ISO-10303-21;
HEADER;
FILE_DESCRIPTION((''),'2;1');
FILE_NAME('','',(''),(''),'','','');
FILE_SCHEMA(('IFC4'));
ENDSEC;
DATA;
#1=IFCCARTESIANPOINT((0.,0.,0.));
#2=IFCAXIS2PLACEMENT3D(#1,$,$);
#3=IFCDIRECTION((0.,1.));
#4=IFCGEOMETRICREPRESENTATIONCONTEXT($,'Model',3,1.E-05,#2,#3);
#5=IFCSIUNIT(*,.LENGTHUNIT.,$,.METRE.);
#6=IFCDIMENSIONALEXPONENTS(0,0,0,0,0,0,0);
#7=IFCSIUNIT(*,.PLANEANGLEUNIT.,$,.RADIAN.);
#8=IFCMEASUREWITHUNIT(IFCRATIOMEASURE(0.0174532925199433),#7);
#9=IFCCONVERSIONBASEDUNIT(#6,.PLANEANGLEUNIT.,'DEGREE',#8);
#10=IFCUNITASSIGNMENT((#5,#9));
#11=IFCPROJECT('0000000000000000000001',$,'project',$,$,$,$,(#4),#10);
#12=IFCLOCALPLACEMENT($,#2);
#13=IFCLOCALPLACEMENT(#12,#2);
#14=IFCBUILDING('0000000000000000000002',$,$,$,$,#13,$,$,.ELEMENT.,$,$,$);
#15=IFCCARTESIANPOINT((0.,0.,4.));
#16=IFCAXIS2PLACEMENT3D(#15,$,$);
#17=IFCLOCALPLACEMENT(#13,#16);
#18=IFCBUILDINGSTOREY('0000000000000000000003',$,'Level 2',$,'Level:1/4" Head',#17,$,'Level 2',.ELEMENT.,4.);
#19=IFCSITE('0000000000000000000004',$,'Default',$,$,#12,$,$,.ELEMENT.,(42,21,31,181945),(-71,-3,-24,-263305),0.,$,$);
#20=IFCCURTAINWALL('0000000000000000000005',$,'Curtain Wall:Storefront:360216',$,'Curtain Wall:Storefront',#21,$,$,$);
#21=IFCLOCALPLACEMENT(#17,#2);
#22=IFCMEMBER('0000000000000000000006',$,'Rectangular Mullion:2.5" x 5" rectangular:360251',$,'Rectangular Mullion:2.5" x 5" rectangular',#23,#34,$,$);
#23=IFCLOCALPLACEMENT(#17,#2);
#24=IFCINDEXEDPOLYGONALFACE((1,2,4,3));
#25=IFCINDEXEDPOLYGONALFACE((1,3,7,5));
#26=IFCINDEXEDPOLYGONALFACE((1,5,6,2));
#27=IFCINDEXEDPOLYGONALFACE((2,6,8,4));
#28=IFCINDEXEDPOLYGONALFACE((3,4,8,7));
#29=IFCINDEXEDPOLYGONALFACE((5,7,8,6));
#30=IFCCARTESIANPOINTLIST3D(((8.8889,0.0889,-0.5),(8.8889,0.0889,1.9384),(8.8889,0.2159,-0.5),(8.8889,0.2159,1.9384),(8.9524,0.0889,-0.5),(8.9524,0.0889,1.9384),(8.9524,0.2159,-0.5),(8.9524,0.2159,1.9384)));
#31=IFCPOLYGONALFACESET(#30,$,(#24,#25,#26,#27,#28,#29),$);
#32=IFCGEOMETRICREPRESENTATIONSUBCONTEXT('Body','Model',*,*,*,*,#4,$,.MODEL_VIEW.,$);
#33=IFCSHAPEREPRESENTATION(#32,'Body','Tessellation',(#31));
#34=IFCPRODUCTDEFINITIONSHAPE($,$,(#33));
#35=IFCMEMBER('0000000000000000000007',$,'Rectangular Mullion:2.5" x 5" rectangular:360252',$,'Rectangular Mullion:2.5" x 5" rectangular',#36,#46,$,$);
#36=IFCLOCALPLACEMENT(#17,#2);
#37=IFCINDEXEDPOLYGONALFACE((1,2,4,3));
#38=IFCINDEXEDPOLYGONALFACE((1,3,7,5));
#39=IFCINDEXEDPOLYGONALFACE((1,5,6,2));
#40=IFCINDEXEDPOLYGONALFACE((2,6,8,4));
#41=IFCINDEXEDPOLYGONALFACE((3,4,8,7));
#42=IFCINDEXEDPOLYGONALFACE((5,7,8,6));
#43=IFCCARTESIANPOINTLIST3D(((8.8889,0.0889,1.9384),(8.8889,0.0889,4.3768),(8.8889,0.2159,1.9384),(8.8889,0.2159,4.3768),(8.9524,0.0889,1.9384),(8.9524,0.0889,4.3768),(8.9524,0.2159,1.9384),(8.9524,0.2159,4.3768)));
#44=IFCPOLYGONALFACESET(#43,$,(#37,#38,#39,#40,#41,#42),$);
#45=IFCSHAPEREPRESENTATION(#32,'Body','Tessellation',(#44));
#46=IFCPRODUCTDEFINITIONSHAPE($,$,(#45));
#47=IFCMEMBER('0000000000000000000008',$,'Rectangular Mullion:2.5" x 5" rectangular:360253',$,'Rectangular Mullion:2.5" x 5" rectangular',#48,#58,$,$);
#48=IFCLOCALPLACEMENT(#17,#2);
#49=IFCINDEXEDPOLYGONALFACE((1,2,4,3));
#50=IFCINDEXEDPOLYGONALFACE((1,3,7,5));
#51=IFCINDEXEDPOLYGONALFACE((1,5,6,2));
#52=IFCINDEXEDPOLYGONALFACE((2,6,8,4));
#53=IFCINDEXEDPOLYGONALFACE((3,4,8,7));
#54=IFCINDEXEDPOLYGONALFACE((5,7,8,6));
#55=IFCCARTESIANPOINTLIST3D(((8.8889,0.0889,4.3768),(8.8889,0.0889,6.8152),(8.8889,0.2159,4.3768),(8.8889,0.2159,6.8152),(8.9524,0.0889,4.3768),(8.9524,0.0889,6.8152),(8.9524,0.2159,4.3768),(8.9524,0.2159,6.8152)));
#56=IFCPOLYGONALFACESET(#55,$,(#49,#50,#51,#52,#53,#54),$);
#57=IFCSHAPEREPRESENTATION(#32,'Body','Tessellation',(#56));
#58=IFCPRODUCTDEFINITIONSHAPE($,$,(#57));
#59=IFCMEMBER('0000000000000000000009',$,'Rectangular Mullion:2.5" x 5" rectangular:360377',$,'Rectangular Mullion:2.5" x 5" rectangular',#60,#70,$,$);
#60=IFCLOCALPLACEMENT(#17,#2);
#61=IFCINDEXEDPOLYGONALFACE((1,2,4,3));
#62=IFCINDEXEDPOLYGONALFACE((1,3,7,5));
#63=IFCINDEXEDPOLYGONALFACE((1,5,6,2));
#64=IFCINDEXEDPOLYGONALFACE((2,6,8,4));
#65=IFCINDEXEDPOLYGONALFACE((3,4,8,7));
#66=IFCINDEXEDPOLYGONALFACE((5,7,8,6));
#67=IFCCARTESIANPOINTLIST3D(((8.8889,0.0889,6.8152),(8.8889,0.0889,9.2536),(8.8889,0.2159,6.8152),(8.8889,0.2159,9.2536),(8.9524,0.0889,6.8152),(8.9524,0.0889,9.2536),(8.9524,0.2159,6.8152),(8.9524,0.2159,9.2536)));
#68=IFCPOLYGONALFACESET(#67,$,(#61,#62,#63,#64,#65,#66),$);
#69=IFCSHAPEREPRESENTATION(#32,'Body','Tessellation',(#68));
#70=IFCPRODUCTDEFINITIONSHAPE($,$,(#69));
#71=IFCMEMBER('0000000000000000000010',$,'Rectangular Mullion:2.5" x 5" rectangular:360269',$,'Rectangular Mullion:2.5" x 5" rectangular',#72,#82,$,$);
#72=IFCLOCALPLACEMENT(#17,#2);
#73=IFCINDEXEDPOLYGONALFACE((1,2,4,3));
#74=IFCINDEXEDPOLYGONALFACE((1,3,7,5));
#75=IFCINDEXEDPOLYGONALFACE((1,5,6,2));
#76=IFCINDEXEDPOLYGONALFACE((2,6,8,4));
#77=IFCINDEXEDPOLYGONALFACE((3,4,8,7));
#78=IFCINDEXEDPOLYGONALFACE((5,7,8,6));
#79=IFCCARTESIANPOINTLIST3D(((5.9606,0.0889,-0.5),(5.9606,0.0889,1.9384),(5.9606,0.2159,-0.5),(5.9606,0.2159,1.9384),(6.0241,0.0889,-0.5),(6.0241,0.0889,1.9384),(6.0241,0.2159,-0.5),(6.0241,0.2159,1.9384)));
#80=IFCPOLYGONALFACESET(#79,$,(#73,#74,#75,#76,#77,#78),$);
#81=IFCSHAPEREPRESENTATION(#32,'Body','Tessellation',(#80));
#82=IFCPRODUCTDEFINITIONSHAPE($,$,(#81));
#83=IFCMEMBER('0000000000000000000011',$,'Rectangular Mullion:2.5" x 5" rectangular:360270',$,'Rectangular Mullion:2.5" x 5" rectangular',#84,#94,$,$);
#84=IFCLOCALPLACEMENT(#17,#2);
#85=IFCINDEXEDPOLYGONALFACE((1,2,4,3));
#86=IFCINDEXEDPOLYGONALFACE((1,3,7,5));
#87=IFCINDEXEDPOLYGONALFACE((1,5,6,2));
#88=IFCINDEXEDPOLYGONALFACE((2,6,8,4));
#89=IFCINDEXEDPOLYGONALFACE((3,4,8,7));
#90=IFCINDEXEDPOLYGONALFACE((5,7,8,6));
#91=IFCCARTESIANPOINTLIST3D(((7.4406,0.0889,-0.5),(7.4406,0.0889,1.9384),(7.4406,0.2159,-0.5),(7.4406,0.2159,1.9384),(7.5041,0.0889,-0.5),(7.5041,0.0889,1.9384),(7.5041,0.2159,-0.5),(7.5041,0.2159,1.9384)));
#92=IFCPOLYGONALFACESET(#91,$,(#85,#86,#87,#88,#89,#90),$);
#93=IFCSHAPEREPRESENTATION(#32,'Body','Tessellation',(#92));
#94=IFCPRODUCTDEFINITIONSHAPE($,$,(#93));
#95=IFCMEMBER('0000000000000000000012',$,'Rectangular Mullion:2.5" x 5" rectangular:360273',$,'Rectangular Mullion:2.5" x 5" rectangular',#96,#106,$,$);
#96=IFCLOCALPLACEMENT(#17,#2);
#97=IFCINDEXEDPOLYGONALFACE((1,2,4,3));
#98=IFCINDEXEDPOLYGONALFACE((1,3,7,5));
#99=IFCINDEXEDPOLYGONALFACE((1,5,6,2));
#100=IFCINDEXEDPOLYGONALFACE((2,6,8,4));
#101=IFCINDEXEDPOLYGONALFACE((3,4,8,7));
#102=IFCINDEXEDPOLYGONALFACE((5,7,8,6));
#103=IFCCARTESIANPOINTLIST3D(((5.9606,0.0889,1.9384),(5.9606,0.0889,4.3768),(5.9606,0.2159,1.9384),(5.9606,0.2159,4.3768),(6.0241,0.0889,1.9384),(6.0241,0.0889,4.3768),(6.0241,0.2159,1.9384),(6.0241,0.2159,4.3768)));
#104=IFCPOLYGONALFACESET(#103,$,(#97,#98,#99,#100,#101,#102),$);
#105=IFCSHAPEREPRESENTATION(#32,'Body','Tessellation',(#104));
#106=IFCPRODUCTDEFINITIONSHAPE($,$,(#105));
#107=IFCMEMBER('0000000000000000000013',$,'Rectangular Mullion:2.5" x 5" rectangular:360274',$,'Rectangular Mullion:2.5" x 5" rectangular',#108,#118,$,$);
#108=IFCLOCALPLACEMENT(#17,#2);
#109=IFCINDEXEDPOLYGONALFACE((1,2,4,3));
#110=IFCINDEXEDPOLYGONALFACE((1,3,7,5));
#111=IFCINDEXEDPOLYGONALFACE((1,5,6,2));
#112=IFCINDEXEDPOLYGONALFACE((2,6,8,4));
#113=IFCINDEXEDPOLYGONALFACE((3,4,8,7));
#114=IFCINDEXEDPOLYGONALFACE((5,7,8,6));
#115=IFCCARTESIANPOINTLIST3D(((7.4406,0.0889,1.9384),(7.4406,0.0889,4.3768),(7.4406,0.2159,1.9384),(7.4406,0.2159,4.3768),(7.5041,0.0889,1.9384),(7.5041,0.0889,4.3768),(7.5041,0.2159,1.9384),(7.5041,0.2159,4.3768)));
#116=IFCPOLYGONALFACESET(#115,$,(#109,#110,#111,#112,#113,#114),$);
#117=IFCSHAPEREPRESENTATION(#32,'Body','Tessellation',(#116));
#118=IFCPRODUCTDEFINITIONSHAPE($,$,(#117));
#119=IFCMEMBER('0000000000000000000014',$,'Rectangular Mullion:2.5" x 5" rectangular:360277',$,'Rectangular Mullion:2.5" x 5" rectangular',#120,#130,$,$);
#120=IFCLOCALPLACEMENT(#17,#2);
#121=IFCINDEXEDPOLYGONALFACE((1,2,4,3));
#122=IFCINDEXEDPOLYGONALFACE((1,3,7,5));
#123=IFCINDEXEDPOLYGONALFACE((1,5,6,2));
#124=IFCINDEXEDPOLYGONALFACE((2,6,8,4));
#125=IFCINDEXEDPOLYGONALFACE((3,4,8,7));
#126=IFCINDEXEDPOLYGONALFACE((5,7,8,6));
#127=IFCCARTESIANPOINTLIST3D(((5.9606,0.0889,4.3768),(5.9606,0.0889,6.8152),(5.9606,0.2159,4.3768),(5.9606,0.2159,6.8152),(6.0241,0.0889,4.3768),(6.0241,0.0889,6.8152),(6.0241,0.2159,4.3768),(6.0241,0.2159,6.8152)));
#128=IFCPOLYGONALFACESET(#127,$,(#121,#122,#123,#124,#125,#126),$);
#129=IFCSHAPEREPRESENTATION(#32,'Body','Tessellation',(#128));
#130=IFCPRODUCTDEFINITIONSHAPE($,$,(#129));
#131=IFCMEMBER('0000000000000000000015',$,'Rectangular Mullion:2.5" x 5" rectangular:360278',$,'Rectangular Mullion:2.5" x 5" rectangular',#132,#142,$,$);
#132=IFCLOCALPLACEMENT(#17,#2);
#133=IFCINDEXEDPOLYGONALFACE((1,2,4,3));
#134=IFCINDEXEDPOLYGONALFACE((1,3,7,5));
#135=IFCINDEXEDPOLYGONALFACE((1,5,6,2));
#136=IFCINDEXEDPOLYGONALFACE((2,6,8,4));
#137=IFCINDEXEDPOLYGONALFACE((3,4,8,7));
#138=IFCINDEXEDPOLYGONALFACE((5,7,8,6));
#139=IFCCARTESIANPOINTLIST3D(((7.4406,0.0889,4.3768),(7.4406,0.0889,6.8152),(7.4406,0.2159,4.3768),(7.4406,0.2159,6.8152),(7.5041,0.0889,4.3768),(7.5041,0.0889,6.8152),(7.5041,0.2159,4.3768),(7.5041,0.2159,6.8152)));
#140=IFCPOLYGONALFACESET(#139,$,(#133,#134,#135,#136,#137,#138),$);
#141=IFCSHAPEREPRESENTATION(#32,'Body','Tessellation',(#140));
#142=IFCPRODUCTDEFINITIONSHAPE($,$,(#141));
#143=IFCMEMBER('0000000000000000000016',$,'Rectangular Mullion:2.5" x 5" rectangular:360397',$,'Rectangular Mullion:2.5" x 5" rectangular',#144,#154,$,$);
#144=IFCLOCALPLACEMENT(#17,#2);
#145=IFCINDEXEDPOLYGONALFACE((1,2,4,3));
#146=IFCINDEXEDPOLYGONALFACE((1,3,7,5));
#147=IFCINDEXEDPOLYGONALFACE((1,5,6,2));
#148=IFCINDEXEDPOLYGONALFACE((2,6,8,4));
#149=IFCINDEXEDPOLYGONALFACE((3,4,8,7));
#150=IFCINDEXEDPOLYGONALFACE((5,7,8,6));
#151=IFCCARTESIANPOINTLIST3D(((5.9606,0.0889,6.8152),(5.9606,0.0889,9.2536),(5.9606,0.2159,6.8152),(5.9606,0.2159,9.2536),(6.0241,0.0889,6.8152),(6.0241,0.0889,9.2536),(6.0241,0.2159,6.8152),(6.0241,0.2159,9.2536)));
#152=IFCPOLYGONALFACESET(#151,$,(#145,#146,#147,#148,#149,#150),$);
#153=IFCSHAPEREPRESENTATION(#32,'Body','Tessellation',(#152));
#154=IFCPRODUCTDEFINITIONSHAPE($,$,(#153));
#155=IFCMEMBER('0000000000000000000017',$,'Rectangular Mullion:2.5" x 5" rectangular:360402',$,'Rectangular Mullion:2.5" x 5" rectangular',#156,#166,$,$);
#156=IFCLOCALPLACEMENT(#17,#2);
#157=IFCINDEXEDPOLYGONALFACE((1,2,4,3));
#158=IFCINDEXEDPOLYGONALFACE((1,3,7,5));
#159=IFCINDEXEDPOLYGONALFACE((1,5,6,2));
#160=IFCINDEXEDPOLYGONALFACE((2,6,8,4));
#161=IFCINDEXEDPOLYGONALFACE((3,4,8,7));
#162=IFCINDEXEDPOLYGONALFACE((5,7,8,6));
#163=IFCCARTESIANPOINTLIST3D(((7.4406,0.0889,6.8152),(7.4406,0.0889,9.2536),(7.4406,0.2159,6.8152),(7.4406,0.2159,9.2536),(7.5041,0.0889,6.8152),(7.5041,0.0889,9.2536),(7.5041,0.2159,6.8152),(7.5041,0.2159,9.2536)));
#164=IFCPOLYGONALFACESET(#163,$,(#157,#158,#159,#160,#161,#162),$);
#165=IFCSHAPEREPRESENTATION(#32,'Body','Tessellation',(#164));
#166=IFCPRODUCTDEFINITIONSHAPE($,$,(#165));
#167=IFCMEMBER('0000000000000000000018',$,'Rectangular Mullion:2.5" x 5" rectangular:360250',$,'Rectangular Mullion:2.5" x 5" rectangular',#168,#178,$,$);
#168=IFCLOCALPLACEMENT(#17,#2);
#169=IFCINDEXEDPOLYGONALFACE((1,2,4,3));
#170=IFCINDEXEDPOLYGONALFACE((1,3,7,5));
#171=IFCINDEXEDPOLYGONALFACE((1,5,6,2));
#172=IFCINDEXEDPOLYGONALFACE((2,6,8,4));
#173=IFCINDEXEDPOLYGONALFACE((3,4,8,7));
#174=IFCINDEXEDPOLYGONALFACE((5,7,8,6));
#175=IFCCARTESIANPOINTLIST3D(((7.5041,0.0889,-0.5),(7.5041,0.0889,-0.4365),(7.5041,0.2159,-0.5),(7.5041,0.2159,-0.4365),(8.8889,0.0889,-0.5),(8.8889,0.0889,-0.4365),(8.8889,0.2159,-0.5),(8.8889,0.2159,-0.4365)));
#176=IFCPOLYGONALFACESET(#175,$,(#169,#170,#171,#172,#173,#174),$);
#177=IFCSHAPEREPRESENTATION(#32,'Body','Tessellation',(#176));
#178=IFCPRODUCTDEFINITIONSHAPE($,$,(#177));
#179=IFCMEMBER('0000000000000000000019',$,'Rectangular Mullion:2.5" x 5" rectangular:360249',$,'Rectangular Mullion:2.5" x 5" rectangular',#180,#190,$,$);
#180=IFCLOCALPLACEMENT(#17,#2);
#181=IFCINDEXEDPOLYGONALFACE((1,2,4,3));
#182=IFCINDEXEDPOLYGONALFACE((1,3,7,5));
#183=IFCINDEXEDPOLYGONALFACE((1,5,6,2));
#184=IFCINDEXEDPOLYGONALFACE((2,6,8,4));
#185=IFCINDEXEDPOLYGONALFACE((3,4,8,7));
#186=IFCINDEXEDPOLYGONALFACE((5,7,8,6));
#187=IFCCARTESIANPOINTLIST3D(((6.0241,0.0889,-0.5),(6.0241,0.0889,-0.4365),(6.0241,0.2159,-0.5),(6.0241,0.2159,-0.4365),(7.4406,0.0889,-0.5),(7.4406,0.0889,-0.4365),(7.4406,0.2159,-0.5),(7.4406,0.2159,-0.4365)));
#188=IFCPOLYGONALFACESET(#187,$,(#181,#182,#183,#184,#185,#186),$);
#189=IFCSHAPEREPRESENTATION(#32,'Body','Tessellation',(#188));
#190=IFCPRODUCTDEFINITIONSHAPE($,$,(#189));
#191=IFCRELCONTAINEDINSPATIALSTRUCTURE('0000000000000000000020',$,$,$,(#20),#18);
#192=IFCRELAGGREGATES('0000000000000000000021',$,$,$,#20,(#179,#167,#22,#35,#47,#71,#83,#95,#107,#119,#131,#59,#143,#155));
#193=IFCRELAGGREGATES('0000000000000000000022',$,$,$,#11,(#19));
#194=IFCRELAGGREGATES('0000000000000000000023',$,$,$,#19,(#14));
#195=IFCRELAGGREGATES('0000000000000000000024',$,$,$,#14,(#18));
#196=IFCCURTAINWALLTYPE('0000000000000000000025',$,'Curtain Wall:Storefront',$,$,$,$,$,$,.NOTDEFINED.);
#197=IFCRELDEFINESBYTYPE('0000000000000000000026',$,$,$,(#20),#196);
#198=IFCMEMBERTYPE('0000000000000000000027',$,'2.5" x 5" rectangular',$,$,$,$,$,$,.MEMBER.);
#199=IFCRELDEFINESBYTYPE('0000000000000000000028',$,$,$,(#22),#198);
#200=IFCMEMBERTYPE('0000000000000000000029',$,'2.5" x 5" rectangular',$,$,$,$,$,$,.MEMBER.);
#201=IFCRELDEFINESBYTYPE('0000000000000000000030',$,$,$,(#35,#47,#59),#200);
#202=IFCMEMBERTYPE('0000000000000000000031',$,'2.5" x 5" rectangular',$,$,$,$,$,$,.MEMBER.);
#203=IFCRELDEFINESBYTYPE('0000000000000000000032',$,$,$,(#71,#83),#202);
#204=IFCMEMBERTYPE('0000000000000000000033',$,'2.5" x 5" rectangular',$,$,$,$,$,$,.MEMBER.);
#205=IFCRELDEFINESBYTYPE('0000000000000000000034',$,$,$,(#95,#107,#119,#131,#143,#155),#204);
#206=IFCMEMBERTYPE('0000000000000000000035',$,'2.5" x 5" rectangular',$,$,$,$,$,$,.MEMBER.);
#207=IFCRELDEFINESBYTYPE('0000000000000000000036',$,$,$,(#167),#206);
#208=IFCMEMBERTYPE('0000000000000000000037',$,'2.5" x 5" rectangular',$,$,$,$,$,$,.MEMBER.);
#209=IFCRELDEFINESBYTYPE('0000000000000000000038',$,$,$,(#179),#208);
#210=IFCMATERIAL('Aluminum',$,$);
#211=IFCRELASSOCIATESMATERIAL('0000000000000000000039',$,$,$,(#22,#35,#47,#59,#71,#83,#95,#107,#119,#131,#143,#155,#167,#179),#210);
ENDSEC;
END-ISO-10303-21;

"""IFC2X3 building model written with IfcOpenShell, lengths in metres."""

from ifc_helpers import new_model, entity, si_unit, converted_unit, direction, frame, origin, origin_2d_with_axis, place, context, subcontext, project, spatial, rectangle, extrude, source, transform, mapped, material, type_object, type_shapes, element, aggregate, save


model = new_model("IFC2X3")

# Units and contexts
model_context = context("Model", 3, precision=1e-05, world=origin(), true_north=direction((0.0, 1.0)))
body_context = subcontext(model_context, "Body", "Model", "MODEL_VIEW")
ifc_project = project(units=[si_unit("LENGTHUNIT", "METRE"), converted_unit("PLANEANGLEUNIT", "DEGREE", entity("IfcRatioMeasure", 0.0174532925199433), si_unit("PLANEANGLEUNIT", "RADIAN"), dimensions=[0, 0, 0, 0, 0, 0, 0])], contexts=[model_context])

# Site, building, storey
site_placement = place(None, origin())
site = spatial("IfcSite", under=ifc_project, at=site_placement, Name="Default", CompositionType="ELEMENT", RefLatitude=(42, 21, 31, 181945), RefLongitude=(-71, -3, -24, -263305), RefElevation=0.0)
building_placement = place(site_placement, origin())
building = spatial("IfcBuilding", under=site, at=building_placement, CompositionType="ELEMENT")
storey_placement = place(building_placement, frame((0.0, 0.0, 4.0)))
storey = spatial("IfcBuildingStorey", under=building, at=storey_placement, Name="Level 2", ObjectType="Level:1/4\" Head", LongName="Level 2", CompositionType="ELEMENT", Elevation=4.0)

# Curtain wall, members
curtain_wall_type = type_object("IfcCurtainWallType", Name="Curtain Wall:Storefront", PredefinedType="NOTDEFINED")
curtain_wall_placement = place(storey_placement, frame((0.0, 0.0, -4.0)))
curtain_wall = element("IfcCurtainWall", 1, at=curtain_wall_placement, inside=storey, type_object=curtain_wall_type, Name="Curtain Wall:Storefront:360216", ObjectType="Curtain Wall:Storefront")
ifc_material_1 = material(Name="Aluminum")
member_type_1 = type_object("IfcMemberType", Name="2.5\" x 5\" rectangular", PredefinedType="MEMBER")
shared_shape_1 = source(origin(), body_context, "Body", "SweptSolid", [
    extrude(rectangle(XDim=0.127, YDim=0.0635, at=origin_2d_with_axis()), frame((-0.0318, 0.0, -2.4384), z_axis=(0.0, 0.0, 1.0), x_axis=(0.0, -1.0, 0.0)), (0.0, 0.0, 1.0), 2.4384),
])
type_shapes(member_type_1, [shared_shape_1])
member_1_placement = place(storey_placement, frame((8.9524, 0.1524, -0.5), z_axis=(0.0, 0.0, -1.0), x_axis=(1.0, 0.0, 0.0)))
member_1 = element("IfcMember", 2, at=member_1_placement, type_object=member_type_1, material=ifc_material_1, Name="Rectangular Mullion:2.5\" x 5\" rectangular:360251", ObjectType="Rectangular Mullion:2.5\" x 5\" rectangular", context=body_context, shape_type="MappedRepresentation", body=[
    mapped(shared_shape_1, transform((0.0, 0.0, 0.0), scale=1.0)),
])
member_type_2 = type_object("IfcMemberType", Name="2.5\" x 5\" rectangular", PredefinedType="MEMBER")
shared_shape_2 = source(origin(), body_context, "Body", "SweptSolid", [
    extrude(rectangle(XDim=0.127, YDim=0.0635, at=origin_2d_with_axis()), frame((-0.0318, 0.0, -2.4384), z_axis=(0.0, 0.0, 1.0), x_axis=(0.0, -1.0, 0.0)), (0.0, 0.0, 1.0), 2.4384),
])
type_shapes(member_type_2, [shared_shape_2])
member_2_placement = place(storey_placement, frame((8.9524, 0.1524, 1.9384), z_axis=(0.0, 0.0, -1.0), x_axis=(1.0, 0.0, 0.0)))
member_2 = element("IfcMember", 3, at=member_2_placement, type_object=member_type_2, material=ifc_material_1, Name="Rectangular Mullion:2.5\" x 5\" rectangular:360252", ObjectType="Rectangular Mullion:2.5\" x 5\" rectangular", context=body_context, shape_type="MappedRepresentation", body=[
    mapped(shared_shape_2, transform((0.0, 0.0, 0.0), scale=1.0)),
])
member_3_placement = place(storey_placement, frame((8.9524, 0.1524, 4.3768), z_axis=(0.0, 0.0, -1.0), x_axis=(1.0, 0.0, 0.0)))
member_3 = element("IfcMember", 4, at=member_3_placement, type_object=member_type_2, material=ifc_material_1, Name="Rectangular Mullion:2.5\" x 5\" rectangular:360253", ObjectType="Rectangular Mullion:2.5\" x 5\" rectangular", context=body_context, shape_type="MappedRepresentation", body=[
    mapped(shared_shape_2, transform((0.0, 0.0, 0.0), scale=1.0)),
])
member_4_placement = place(storey_placement, frame((8.9524, 0.1524, 6.8152), z_axis=(0.0, 0.0, -1.0), x_axis=(1.0, 0.0, 0.0)))
member_4 = element("IfcMember", 5, at=member_4_placement, type_object=member_type_2, material=ifc_material_1, Name="Rectangular Mullion:2.5\" x 5\" rectangular:360377", ObjectType="Rectangular Mullion:2.5\" x 5\" rectangular", context=body_context, shape_type="MappedRepresentation", body=[
    mapped(shared_shape_2, transform((0.0, 0.0, 0.0), scale=1.0)),
])
member_type_3 = type_object("IfcMemberType", Name="2.5\" x 5\" rectangular", PredefinedType="MEMBER")
shared_shape_3 = source(origin(), body_context, "Body", "SweptSolid", [
    extrude(rectangle(XDim=0.127, YDim=0.0635, at=origin_2d_with_axis()), frame((0.0, 0.0, -2.4384), z_axis=(0.0, 0.0, 1.0), x_axis=(0.0, -1.0, 0.0)), (0.0, 0.0, 1.0), 2.4384),
])
type_shapes(member_type_3, [shared_shape_3])
member_5_placement = place(storey_placement, frame((5.9924, 0.1524, -0.5), z_axis=(0.0, 0.0, -1.0), x_axis=(1.0, 0.0, 0.0)))
member_5 = element("IfcMember", 6, at=member_5_placement, type_object=member_type_3, material=ifc_material_1, Name="Rectangular Mullion:2.5\" x 5\" rectangular:360269", ObjectType="Rectangular Mullion:2.5\" x 5\" rectangular", context=body_context, shape_type="MappedRepresentation", body=[
    mapped(shared_shape_3, transform((0.0, 0.0, 0.0), scale=1.0)),
])
member_6_placement = place(storey_placement, frame((7.4724, 0.1524, -0.5), z_axis=(0.0, 0.0, -1.0), x_axis=(1.0, 0.0, 0.0)))
member_6 = element("IfcMember", 7, at=member_6_placement, type_object=member_type_3, material=ifc_material_1, Name="Rectangular Mullion:2.5\" x 5\" rectangular:360270", ObjectType="Rectangular Mullion:2.5\" x 5\" rectangular", context=body_context, shape_type="MappedRepresentation", body=[
    mapped(shared_shape_3, transform((0.0, 0.0, 0.0), scale=1.0)),
])
member_type_4 = type_object("IfcMemberType", Name="2.5\" x 5\" rectangular", PredefinedType="MEMBER")
shared_shape_4 = source(origin(), body_context, "Body", "SweptSolid", [
    extrude(rectangle(XDim=0.127, YDim=0.0635, at=origin_2d_with_axis()), frame((0.0, 0.0, -2.4384), z_axis=(0.0, 0.0, 1.0), x_axis=(0.0, -1.0, 0.0)), (0.0, 0.0, 1.0), 2.4384),
])
type_shapes(member_type_4, [shared_shape_4])
member_7_placement = place(storey_placement, frame((5.9924, 0.1524, 1.9384), z_axis=(0.0, 0.0, -1.0), x_axis=(1.0, 0.0, 0.0)))
member_7 = element("IfcMember", 8, at=member_7_placement, type_object=member_type_4, material=ifc_material_1, Name="Rectangular Mullion:2.5\" x 5\" rectangular:360273", ObjectType="Rectangular Mullion:2.5\" x 5\" rectangular", context=body_context, shape_type="MappedRepresentation", body=[
    mapped(shared_shape_4, transform((0.0, 0.0, 0.0), scale=1.0)),
])
member_8_placement = place(storey_placement, frame((7.4724, 0.1524, 1.9384), z_axis=(0.0, 0.0, -1.0), x_axis=(1.0, 0.0, 0.0)))
member_8 = element("IfcMember", 9, at=member_8_placement, type_object=member_type_4, material=ifc_material_1, Name="Rectangular Mullion:2.5\" x 5\" rectangular:360274", ObjectType="Rectangular Mullion:2.5\" x 5\" rectangular", context=body_context, shape_type="MappedRepresentation", body=[
    mapped(shared_shape_4, transform((0.0, 0.0, 0.0), scale=1.0)),
])
member_9_placement = place(storey_placement, frame((5.9924, 0.1524, 4.3768), z_axis=(0.0, 0.0, -1.0), x_axis=(1.0, 0.0, 0.0)))
member_9 = element("IfcMember", 10, at=member_9_placement, type_object=member_type_4, material=ifc_material_1, Name="Rectangular Mullion:2.5\" x 5\" rectangular:360277", ObjectType="Rectangular Mullion:2.5\" x 5\" rectangular", context=body_context, shape_type="MappedRepresentation", body=[
    mapped(shared_shape_4, transform((0.0, 0.0, 0.0), scale=1.0)),
])
member_10_placement = place(storey_placement, frame((7.4724, 0.1524, 4.3768), z_axis=(0.0, 0.0, -1.0), x_axis=(1.0, 0.0, 0.0)))
member_10 = element("IfcMember", 11, at=member_10_placement, type_object=member_type_4, material=ifc_material_1, Name="Rectangular Mullion:2.5\" x 5\" rectangular:360278", ObjectType="Rectangular Mullion:2.5\" x 5\" rectangular", context=body_context, shape_type="MappedRepresentation", body=[
    mapped(shared_shape_4, transform((0.0, 0.0, 0.0), scale=1.0)),
])
member_11_placement = place(storey_placement, frame((5.9924, 0.1524, 6.8152), z_axis=(0.0, 0.0, -1.0), x_axis=(1.0, 0.0, 0.0)))
member_11 = element("IfcMember", 12, at=member_11_placement, type_object=member_type_4, material=ifc_material_1, Name="Rectangular Mullion:2.5\" x 5\" rectangular:360397", ObjectType="Rectangular Mullion:2.5\" x 5\" rectangular", context=body_context, shape_type="MappedRepresentation", body=[
    mapped(shared_shape_4, transform((0.0, 0.0, 0.0), scale=1.0)),
])
member_12_placement = place(storey_placement, frame((7.4724, 0.1524, 6.8152), z_axis=(0.0, 0.0, -1.0), x_axis=(1.0, 0.0, 0.0)))
member_12 = element("IfcMember", 13, at=member_12_placement, type_object=member_type_4, material=ifc_material_1, Name="Rectangular Mullion:2.5\" x 5\" rectangular:360402", ObjectType="Rectangular Mullion:2.5\" x 5\" rectangular", context=body_context, shape_type="MappedRepresentation", body=[
    mapped(shared_shape_4, transform((0.0, 0.0, 0.0), scale=1.0)),
])
member_type_5 = type_object("IfcMemberType", Name="2.5\" x 5\" rectangular", PredefinedType="MEMBER")
shared_shape_5 = source(origin(), body_context, "Body", "SweptSolid", [
    extrude(rectangle(XDim=0.127, YDim=0.0635, at=origin_2d_with_axis()), frame((-0.0318, 0.0, -1.3848), z_axis=(0.0, 0.0, 1.0), x_axis=(0.0, -1.0, 0.0)), (0.0, 0.0, 1.0), 1.3848),
])
type_shapes(member_type_5, [shared_shape_5])
member_13_placement = place(storey_placement, frame((7.5041, 0.1524, -0.5), z_axis=(-1.0, 0.0, 0.0), x_axis=(0.0, 0.0, -1.0)))
member_13 = element("IfcMember", 14, at=member_13_placement, type_object=member_type_5, material=ifc_material_1, Name="Rectangular Mullion:2.5\" x 5\" rectangular:360250", ObjectType="Rectangular Mullion:2.5\" x 5\" rectangular", context=body_context, shape_type="MappedRepresentation", body=[
    mapped(shared_shape_5, transform((0.0, 0.0, 0.0), scale=1.0)),
])
member_type_6 = type_object("IfcMemberType", Name="2.5\" x 5\" rectangular", PredefinedType="MEMBER")
shared_shape_6 = source(origin(), body_context, "Body", "SweptSolid", [
    extrude(rectangle(XDim=0.127, YDim=0.0635, at=origin_2d_with_axis()), frame((-0.0318, 0.0, -1.4165), z_axis=(0.0, 0.0, 1.0), x_axis=(0.0, -1.0, 0.0)), (0.0, 0.0, 1.0), 1.4165),
])
type_shapes(member_type_6, [shared_shape_6])
member_14_placement = place(storey_placement, frame((6.0241, 0.1524, -0.5), z_axis=(-1.0, 0.0, 0.0), x_axis=(0.0, 0.0, -1.0)))
member_14 = element("IfcMember", 15, at=member_14_placement, type_object=member_type_6, material=ifc_material_1, Name="Rectangular Mullion:2.5\" x 5\" rectangular:360249", ObjectType="Rectangular Mullion:2.5\" x 5\" rectangular", context=body_context, shape_type="MappedRepresentation", body=[
    mapped(shared_shape_6, transform((0.0, 0.0, 0.0), scale=1.0)),
])
aggregate(curtain_wall, [member_14, member_13, member_1, member_2, member_3, member_5, member_6, member_7, member_8, member_9, member_10, member_4, member_11, member_12])

save(model, "model.ifc")
